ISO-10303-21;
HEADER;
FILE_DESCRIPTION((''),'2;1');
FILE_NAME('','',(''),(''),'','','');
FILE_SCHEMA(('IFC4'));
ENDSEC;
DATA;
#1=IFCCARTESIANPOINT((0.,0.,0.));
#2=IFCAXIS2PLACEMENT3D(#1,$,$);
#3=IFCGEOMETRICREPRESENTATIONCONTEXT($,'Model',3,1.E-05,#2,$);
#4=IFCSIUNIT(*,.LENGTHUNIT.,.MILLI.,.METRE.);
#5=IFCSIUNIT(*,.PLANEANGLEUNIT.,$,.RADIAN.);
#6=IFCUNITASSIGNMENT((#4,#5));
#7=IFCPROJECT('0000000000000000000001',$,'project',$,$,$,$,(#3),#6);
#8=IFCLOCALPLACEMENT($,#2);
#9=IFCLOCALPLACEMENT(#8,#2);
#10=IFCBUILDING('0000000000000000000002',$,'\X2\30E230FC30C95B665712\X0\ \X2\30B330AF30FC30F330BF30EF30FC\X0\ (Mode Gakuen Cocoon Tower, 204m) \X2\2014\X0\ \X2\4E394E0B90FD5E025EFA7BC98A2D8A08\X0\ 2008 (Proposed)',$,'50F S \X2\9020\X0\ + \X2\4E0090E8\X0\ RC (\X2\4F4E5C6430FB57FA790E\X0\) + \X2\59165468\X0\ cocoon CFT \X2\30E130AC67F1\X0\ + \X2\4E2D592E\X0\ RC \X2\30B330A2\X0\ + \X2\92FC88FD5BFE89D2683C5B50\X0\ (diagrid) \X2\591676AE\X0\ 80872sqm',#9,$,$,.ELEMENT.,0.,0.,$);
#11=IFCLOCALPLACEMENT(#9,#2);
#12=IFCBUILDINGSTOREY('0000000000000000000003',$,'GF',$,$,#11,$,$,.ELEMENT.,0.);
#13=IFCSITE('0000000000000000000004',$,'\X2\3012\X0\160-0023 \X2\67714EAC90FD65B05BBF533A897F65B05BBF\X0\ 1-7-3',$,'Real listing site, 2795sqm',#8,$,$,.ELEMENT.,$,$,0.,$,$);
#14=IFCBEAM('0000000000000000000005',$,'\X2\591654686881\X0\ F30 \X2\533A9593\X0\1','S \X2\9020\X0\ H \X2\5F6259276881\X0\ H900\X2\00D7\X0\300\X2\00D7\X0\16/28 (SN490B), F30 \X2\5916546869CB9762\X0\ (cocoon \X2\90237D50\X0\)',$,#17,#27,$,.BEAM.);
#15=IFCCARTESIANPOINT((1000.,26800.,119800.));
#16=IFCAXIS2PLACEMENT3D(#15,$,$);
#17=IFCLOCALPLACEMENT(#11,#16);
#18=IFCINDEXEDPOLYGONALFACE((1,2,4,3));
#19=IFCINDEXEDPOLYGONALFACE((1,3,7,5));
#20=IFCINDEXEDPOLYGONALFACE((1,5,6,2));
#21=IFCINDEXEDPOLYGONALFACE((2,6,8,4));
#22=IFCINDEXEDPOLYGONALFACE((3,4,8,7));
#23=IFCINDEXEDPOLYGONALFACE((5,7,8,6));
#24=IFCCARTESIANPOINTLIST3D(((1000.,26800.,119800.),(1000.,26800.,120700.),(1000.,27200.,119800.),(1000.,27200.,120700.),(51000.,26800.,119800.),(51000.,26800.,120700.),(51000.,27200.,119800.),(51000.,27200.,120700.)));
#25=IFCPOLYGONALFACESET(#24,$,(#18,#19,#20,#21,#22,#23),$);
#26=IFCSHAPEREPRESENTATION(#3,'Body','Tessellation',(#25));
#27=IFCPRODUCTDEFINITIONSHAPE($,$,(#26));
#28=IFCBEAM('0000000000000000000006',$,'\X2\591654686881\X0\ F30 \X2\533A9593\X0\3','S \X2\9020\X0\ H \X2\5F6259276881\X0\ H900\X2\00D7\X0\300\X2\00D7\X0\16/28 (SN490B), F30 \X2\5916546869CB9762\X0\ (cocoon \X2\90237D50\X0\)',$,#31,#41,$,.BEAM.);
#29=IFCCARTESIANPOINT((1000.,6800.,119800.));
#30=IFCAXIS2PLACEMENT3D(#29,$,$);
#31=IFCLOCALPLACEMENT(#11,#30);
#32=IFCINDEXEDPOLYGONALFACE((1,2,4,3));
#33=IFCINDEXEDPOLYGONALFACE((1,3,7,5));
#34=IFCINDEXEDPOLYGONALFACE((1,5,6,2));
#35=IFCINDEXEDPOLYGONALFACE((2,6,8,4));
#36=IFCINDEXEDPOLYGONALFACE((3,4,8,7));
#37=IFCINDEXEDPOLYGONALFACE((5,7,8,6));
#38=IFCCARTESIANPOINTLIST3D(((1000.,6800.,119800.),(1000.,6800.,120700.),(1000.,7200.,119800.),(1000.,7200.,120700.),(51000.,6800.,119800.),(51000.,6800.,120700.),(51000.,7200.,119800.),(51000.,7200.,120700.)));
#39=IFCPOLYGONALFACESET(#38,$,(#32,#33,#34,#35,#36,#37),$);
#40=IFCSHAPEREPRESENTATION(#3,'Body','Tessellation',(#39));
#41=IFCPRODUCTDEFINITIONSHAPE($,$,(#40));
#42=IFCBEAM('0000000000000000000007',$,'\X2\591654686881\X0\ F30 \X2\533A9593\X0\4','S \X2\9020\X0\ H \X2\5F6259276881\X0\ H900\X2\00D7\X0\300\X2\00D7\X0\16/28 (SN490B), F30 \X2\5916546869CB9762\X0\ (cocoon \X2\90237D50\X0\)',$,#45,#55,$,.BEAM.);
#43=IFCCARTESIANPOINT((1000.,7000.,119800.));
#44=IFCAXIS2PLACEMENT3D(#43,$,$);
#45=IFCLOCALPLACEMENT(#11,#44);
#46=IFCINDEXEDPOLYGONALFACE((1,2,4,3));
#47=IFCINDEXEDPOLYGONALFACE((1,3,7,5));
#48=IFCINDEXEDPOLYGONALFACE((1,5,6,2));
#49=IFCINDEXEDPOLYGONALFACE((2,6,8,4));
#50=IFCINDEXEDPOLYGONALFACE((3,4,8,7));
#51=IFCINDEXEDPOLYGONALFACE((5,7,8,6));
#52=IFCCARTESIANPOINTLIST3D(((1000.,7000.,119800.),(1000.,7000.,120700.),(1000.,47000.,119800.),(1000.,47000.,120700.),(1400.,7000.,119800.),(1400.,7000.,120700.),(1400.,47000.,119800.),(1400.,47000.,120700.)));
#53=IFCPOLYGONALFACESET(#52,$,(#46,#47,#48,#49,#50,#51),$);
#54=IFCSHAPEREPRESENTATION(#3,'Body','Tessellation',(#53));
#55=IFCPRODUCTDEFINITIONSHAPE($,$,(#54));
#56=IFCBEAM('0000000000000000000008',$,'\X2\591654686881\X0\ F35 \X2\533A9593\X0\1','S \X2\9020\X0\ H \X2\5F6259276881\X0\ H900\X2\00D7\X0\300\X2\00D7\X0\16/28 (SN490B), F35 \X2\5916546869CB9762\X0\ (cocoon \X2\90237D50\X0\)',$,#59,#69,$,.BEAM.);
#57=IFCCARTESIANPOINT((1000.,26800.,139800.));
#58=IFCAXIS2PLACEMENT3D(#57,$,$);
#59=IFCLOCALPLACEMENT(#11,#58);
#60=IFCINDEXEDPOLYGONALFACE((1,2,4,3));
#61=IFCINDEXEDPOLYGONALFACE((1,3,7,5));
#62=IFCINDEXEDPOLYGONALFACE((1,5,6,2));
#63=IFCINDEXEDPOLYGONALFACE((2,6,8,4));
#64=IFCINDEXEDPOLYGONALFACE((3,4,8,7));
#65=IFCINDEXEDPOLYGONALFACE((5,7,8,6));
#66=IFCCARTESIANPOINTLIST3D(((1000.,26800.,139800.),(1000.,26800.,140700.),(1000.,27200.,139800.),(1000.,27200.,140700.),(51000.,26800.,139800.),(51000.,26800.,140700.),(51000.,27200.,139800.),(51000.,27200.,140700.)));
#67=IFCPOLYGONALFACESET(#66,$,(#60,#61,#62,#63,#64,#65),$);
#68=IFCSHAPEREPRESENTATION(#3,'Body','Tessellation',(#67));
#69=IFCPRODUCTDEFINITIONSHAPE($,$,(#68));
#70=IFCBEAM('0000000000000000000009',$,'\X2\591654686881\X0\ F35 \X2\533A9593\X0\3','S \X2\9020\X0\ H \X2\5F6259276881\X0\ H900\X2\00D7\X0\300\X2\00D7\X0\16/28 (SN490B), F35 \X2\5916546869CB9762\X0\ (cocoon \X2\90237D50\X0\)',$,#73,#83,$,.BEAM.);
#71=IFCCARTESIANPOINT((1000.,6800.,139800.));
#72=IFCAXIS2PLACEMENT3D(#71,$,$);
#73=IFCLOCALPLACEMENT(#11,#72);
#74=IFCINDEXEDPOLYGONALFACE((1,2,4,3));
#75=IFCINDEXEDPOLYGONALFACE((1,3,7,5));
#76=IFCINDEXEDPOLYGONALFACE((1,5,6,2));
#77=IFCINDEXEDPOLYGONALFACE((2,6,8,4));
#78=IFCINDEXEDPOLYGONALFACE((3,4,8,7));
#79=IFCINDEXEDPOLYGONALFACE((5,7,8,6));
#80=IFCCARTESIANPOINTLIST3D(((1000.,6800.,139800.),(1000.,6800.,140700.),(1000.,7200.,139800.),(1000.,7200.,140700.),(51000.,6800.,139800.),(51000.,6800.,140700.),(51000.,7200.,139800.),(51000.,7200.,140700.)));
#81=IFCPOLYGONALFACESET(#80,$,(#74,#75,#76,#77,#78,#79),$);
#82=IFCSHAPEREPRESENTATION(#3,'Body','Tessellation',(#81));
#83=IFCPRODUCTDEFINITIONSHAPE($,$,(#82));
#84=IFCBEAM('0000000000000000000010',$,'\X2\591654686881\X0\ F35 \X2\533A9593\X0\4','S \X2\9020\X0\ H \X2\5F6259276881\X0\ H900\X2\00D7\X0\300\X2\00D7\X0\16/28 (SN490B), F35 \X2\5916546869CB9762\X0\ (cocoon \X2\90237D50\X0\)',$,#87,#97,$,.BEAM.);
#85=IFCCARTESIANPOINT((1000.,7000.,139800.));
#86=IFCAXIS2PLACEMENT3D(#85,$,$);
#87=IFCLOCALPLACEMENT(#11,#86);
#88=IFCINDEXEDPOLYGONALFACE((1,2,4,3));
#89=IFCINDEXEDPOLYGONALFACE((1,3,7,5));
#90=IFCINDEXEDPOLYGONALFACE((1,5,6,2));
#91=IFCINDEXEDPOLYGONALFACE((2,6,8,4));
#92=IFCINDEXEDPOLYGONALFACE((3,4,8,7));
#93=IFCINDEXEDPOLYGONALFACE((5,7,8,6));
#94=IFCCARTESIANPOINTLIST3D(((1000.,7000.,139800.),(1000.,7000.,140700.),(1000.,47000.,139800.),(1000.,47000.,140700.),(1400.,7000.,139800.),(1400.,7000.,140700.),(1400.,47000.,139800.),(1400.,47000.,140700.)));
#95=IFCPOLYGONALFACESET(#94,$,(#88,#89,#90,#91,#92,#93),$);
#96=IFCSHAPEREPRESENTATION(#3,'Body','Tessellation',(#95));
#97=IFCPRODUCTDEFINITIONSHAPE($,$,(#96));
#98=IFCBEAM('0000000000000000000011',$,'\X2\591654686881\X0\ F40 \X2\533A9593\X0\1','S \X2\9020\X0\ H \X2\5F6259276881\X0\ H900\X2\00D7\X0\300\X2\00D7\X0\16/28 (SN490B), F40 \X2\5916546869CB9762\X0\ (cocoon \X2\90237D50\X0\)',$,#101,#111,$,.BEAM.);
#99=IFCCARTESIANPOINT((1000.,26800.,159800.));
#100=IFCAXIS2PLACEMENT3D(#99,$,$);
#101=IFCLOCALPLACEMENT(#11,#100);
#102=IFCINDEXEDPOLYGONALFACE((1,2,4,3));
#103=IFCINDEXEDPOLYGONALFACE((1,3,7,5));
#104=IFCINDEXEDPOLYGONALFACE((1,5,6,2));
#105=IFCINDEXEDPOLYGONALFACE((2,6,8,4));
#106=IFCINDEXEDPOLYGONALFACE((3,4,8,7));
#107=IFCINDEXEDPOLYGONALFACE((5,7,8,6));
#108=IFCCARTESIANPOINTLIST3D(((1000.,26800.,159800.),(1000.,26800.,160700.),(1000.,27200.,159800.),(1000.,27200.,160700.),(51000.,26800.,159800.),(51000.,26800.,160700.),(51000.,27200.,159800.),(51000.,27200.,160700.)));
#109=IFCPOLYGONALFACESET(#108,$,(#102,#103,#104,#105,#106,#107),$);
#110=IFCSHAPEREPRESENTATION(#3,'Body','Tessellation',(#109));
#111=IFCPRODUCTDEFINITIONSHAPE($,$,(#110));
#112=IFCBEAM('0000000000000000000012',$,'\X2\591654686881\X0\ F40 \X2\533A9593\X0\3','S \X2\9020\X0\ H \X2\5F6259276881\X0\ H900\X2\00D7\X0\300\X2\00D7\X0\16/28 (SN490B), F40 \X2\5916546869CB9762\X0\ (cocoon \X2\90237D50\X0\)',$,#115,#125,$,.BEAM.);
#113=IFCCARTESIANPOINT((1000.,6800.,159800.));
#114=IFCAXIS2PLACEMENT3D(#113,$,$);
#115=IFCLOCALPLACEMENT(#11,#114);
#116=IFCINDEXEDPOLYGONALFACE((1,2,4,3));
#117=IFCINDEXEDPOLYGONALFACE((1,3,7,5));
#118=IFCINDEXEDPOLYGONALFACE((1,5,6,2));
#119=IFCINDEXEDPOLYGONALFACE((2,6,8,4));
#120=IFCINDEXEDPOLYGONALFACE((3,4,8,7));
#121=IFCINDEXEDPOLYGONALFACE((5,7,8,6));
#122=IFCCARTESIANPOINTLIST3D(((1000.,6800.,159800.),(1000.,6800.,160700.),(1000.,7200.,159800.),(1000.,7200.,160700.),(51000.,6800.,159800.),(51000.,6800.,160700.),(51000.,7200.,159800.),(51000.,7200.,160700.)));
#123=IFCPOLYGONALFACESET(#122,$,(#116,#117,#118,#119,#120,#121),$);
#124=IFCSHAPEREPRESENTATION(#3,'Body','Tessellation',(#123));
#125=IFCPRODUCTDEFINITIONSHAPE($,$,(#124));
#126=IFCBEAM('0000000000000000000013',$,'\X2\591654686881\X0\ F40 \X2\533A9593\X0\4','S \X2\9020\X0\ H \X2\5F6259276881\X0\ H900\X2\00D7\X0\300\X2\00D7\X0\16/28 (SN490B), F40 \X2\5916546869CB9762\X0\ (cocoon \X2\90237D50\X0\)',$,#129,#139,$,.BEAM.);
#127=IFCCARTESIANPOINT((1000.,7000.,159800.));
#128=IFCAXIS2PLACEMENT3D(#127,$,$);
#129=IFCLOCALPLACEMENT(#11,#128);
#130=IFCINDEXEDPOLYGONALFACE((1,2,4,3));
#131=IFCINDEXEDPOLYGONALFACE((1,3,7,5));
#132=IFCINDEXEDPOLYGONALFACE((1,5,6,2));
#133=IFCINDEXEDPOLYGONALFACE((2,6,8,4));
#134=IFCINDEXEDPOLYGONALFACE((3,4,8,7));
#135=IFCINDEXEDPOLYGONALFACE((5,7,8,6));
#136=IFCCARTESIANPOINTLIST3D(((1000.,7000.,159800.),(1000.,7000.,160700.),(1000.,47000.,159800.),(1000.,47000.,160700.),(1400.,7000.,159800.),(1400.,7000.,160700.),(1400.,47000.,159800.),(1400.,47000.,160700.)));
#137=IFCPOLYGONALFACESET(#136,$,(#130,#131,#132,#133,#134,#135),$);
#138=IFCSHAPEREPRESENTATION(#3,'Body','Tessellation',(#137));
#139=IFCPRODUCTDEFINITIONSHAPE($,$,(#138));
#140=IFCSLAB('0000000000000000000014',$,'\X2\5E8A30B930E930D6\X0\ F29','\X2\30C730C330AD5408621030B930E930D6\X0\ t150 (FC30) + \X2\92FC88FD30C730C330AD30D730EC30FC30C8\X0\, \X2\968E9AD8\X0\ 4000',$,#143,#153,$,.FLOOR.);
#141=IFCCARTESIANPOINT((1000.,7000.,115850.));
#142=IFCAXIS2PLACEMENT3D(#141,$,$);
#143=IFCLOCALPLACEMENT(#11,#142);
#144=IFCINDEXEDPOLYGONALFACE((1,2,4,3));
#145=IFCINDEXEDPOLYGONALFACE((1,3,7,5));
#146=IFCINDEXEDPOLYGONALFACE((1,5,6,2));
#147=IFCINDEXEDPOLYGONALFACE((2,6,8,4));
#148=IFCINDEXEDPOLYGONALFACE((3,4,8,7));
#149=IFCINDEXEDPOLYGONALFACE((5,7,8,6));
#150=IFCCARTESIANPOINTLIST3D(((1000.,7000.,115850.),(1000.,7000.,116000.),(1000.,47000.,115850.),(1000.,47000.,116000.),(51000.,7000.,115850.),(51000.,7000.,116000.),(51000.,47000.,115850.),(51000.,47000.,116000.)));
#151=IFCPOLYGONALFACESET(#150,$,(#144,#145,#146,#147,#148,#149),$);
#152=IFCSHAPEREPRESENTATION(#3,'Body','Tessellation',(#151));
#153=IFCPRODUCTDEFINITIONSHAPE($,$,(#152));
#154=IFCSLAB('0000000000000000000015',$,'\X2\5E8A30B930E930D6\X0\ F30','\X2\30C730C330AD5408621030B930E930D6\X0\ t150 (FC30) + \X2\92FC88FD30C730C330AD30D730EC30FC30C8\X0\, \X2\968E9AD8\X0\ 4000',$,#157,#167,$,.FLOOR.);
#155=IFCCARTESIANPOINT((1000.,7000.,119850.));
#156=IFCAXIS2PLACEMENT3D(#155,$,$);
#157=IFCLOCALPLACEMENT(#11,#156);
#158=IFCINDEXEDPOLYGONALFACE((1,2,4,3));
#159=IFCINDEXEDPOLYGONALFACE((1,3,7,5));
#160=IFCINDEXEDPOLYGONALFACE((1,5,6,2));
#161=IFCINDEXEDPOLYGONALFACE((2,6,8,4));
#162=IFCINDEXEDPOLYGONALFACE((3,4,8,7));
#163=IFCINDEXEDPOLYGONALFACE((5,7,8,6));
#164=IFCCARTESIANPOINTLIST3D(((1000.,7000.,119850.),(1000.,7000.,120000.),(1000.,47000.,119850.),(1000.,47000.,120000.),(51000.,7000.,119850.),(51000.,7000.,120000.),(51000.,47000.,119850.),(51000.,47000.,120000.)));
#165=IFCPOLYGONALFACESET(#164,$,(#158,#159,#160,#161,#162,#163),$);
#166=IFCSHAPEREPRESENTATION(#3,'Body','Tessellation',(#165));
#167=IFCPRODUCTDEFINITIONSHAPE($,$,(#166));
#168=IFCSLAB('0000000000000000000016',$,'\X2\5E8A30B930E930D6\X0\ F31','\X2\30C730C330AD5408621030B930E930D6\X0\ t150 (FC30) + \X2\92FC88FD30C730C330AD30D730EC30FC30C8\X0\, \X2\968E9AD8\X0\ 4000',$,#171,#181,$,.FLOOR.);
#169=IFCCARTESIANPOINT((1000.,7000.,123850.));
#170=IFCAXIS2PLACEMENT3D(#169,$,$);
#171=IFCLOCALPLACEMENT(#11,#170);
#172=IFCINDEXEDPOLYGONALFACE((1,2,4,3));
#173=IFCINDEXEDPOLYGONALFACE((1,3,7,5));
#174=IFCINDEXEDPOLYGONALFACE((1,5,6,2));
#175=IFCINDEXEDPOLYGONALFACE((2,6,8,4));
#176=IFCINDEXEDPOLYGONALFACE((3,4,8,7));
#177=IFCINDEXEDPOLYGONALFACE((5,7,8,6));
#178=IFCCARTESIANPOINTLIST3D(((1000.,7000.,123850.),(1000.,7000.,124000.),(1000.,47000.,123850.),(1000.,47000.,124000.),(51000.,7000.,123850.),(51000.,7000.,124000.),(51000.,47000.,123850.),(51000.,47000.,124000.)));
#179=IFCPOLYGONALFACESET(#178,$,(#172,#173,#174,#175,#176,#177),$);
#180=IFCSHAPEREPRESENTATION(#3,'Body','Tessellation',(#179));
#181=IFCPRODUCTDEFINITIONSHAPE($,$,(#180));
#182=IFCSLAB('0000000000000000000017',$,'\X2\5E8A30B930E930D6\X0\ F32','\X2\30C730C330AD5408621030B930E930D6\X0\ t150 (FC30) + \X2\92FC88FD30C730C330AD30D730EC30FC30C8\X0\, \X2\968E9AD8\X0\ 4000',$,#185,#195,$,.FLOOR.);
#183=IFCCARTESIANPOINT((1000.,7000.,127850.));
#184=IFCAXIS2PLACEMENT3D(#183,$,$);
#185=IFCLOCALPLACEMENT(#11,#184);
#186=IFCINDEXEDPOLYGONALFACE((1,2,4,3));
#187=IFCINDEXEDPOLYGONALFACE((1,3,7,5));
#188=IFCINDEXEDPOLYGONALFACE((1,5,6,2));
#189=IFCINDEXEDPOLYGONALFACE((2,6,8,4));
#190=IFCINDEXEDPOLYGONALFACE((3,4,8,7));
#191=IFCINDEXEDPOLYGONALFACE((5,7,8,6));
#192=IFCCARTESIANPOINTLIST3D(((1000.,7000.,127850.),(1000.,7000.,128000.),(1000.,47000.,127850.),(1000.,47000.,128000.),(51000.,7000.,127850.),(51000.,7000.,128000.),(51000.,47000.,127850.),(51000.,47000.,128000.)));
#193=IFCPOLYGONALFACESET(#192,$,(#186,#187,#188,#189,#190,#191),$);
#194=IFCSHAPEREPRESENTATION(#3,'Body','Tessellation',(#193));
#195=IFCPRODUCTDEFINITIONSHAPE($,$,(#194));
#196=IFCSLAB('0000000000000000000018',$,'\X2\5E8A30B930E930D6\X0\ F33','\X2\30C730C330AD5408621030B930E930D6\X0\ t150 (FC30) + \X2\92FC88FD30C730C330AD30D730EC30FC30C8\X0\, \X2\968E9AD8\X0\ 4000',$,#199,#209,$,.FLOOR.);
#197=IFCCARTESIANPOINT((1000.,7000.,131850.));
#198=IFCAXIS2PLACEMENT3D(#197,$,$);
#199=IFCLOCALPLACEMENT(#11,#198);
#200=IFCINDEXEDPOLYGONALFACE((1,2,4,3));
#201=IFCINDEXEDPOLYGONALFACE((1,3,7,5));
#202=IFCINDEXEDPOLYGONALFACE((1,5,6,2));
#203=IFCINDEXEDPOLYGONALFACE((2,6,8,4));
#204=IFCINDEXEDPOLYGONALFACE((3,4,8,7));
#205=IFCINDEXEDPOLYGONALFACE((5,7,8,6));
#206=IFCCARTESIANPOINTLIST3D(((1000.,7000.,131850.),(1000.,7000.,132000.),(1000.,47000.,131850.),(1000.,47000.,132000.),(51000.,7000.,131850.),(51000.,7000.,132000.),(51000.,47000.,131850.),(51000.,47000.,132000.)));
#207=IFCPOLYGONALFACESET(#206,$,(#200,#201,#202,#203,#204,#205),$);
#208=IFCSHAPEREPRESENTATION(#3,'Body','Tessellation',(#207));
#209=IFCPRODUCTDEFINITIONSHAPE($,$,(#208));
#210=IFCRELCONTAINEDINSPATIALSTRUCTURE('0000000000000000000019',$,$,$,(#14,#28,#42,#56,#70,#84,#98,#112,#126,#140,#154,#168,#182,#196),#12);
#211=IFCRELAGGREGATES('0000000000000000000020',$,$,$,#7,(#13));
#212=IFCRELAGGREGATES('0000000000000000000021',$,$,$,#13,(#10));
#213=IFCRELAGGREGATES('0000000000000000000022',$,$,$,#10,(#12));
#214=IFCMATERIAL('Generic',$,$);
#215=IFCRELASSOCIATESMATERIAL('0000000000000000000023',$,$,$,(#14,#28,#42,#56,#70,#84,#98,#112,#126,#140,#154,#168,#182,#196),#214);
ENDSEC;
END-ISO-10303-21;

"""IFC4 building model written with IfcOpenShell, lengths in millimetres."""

from ifc_helpers import new_model, si_unit, frame, frame_2d, origin, place, context, project, spatial, rectangle, extrude, material, element, save


model = new_model("IFC4")

# Units and contexts
model_context = context("Model", 3, precision=1e-05, world=origin())
ifc_project = project(units=[si_unit("LENGTHUNIT", "METRE", prefix="MILLI"), si_unit("PLANEANGLEUNIT", "RADIAN")], contexts=[model_context])

# Site, building, storey
site_placement = place(None, origin())
site = spatial("IfcSite", under=ifc_project, at=site_placement, Name="〒160-0023 東京都新宿区西新宿 1-7-3", ObjectType="Real listing site, 2795sqm", CompositionType="ELEMENT", RefElevation=0.0)
building_placement = place(site_placement, origin())
building = spatial("IfcBuilding", under=site, at=building_placement, Name="モード学園 コクーンタワー (Mode Gakuen Cocoon Tower, 204m) — 丹下都市建築設計 2008 (Proposed)", ObjectType="50F S 造 + 一部 RC (低層・基礎) + 外周 cocoon CFT メガ柱 + 中央 RC コア + 鋼製対角格子 (diagrid) 外皮 80872sqm", CompositionType="ELEMENT", ElevationOfRefHeight=0.0, ElevationOfTerrain=0.0)
storey_placement = place(building_placement, origin())
storey = spatial("IfcBuildingStorey", under=building, at=storey_placement, Name="GF", CompositionType="ELEMENT", Elevation=0.0)

# Beams
ifc_material_1 = material(Name="Generic")
beam_1_placement = place(storey_placement, frame((1000.0, 26800.0, 119800.0)))
element("IfcBeam", 1, at=beam_1_placement, inside=storey, material=ifc_material_1, Name="外周梁 F30 区間1", Description="S 造 H 形大梁 H900×300×16/28 (SN490B), F30 外周構面 (cocoon 連結)", PredefinedType="BEAM", context=model_context, shape_type="SweptSolid", body=[
    extrude(rectangle(XDim=50000.0, YDim=400.0, at=frame_2d((25000.0, 200.0))), frame((1000.0, 26800.0, 119800.0)), (0.0, 0.0, 1.0), 900.0),
])
beam_2_placement = place(storey_placement, frame((1000.0, 6800.0, 119800.0)))
element("IfcBeam", 2, at=beam_2_placement, inside=storey, material=ifc_material_1, Name="外周梁 F30 区間3", Description="S 造 H 形大梁 H900×300×16/28 (SN490B), F30 外周構面 (cocoon 連結)", PredefinedType="BEAM", context=model_context, shape_type="SweptSolid", body=[
    extrude(rectangle(XDim=50000.0, YDim=400.0, at=frame_2d((25000.0, 200.0))), frame((1000.0, 6800.0, 119800.0)), (0.0, 0.0, 1.0), 900.0),
])
beam_3_placement = place(storey_placement, frame((1000.0, 7000.0, 119800.0)))
element("IfcBeam", 3, at=beam_3_placement, inside=storey, material=ifc_material_1, Name="外周梁 F30 区間4", Description="S 造 H 形大梁 H900×300×16/28 (SN490B), F30 外周構面 (cocoon 連結)", PredefinedType="BEAM", context=model_context, shape_type="SweptSolid", body=[
    extrude(rectangle(XDim=400.0, YDim=40000.0, at=frame_2d((200.0, 20000.0))), frame((1000.0, 7000.0, 119800.0)), (0.0, 0.0, 1.0), 900.0),
])
beam_4_placement = place(storey_placement, frame((1000.0, 26800.0, 139800.0)))
element("IfcBeam", 4, at=beam_4_placement, inside=storey, material=ifc_material_1, Name="外周梁 F35 区間1", Description="S 造 H 形大梁 H900×300×16/28 (SN490B), F35 外周構面 (cocoon 連結)", PredefinedType="BEAM", context=model_context, shape_type="SweptSolid", body=[
    extrude(rectangle(XDim=50000.0, YDim=400.0, at=frame_2d((25000.0, 200.0))), frame((1000.0, 26800.0, 139800.0)), (0.0, 0.0, 1.0), 900.0),
])
beam_5_placement = place(storey_placement, frame((1000.0, 6800.0, 139800.0)))
element("IfcBeam", 5, at=beam_5_placement, inside=storey, material=ifc_material_1, Name="外周梁 F35 区間3", Description="S 造 H 形大梁 H900×300×16/28 (SN490B), F35 外周構面 (cocoon 連結)", PredefinedType="BEAM", context=model_context, shape_type="SweptSolid", body=[
    extrude(rectangle(XDim=50000.0, YDim=400.0, at=frame_2d((25000.0, 200.0))), frame((1000.0, 6800.0, 139800.0)), (0.0, 0.0, 1.0), 900.0),
])
beam_6_placement = place(storey_placement, frame((1000.0, 7000.0, 139800.0)))
element("IfcBeam", 6, at=beam_6_placement, inside=storey, material=ifc_material_1, Name="外周梁 F35 区間4", Description="S 造 H 形大梁 H900×300×16/28 (SN490B), F35 外周構面 (cocoon 連結)", PredefinedType="BEAM", context=model_context, shape_type="SweptSolid", body=[
    extrude(rectangle(XDim=400.0, YDim=40000.0, at=frame_2d((200.0, 20000.0))), frame((1000.0, 7000.0, 139800.0)), (0.0, 0.0, 1.0), 900.0),
])
beam_7_placement = place(storey_placement, frame((1000.0, 26800.0, 159800.0)))
element("IfcBeam", 7, at=beam_7_placement, inside=storey, material=ifc_material_1, Name="外周梁 F40 区間1", Description="S 造 H 形大梁 H900×300×16/28 (SN490B), F40 外周構面 (cocoon 連結)", PredefinedType="BEAM", context=model_context, shape_type="SweptSolid", body=[
    extrude(rectangle(XDim=50000.0, YDim=400.0, at=frame_2d((25000.0, 200.0))), frame((1000.0, 26800.0, 159800.0)), (0.0, 0.0, 1.0), 900.0),
])
beam_8_placement = place(storey_placement, frame((1000.0, 6800.0, 159800.0)))
element("IfcBeam", 8, at=beam_8_placement, inside=storey, material=ifc_material_1, Name="外周梁 F40 区間3", Description="S 造 H 形大梁 H900×300×16/28 (SN490B), F40 外周構面 (cocoon 連結)", PredefinedType="BEAM", context=model_context, shape_type="SweptSolid", body=[
    extrude(rectangle(XDim=50000.0, YDim=400.0, at=frame_2d((25000.0, 200.0))), frame((1000.0, 6800.0, 159800.0)), (0.0, 0.0, 1.0), 900.0),
])
beam_9_placement = place(storey_placement, frame((1000.0, 7000.0, 159800.0)))
element("IfcBeam", 9, at=beam_9_placement, inside=storey, material=ifc_material_1, Name="外周梁 F40 区間4", Description="S 造 H 形大梁 H900×300×16/28 (SN490B), F40 外周構面 (cocoon 連結)", PredefinedType="BEAM", context=model_context, shape_type="SweptSolid", body=[
    extrude(rectangle(XDim=400.0, YDim=40000.0, at=frame_2d((200.0, 20000.0))), frame((1000.0, 7000.0, 159800.0)), (0.0, 0.0, 1.0), 900.0),
])

# Slabs
slab_1_placement = place(storey_placement, frame((1000.0, 7000.0, 115850.0)))
element("IfcSlab", 10, at=slab_1_placement, inside=storey, material=ifc_material_1, Name="床スラブ F29", Description="デッキ合成スラブ t150 (FC30) + 鋼製デッキプレート, 階高 4000", PredefinedType="FLOOR", context=model_context, shape_type="SweptSolid", body=[
    extrude(rectangle(XDim=50000.0, YDim=40000.0, at=frame_2d((25000.0, 20000.0))), frame((1000.0, 7000.0, 115850.0)), (0.0, 0.0, 1.0), 150.0),
])
slab_2_placement = place(storey_placement, frame((1000.0, 7000.0, 119850.0)))
element("IfcSlab", 11, at=slab_2_placement, inside=storey, material=ifc_material_1, Name="床スラブ F30", Description="デッキ合成スラブ t150 (FC30) + 鋼製デッキプレート, 階高 4000", PredefinedType="FLOOR", context=model_context, shape_type="SweptSolid", body=[
    extrude(rectangle(XDim=50000.0, YDim=40000.0, at=frame_2d((25000.0, 20000.0))), frame((1000.0, 7000.0, 119850.0)), (0.0, 0.0, 1.0), 150.0),
])
slab_3_placement = place(storey_placement, frame((1000.0, 7000.0, 123850.0)))
element("IfcSlab", 12, at=slab_3_placement, inside=storey, material=ifc_material_1, Name="床スラブ F31", Description="デッキ合成スラブ t150 (FC30) + 鋼製デッキプレート, 階高 4000", PredefinedType="FLOOR", context=model_context, shape_type="SweptSolid", body=[
    extrude(rectangle(XDim=50000.0, YDim=40000.0, at=frame_2d((25000.0, 20000.0))), frame((1000.0, 7000.0, 123850.0)), (0.0, 0.0, 1.0), 150.0),
])
slab_4_placement = place(storey_placement, frame((1000.0, 7000.0, 127850.0)))
element("IfcSlab", 13, at=slab_4_placement, inside=storey, material=ifc_material_1, Name="床スラブ F32", Description="デッキ合成スラブ t150 (FC30) + 鋼製デッキプレート, 階高 4000", PredefinedType="FLOOR", context=model_context, shape_type="SweptSolid", body=[
    extrude(rectangle(XDim=50000.0, YDim=40000.0, at=frame_2d((25000.0, 20000.0))), frame((1000.0, 7000.0, 127850.0)), (0.0, 0.0, 1.0), 150.0),
])
slab_5_placement = place(storey_placement, frame((1000.0, 7000.0, 131850.0)))
element("IfcSlab", 14, at=slab_5_placement, inside=storey, material=ifc_material_1, Name="床スラブ F33", Description="デッキ合成スラブ t150 (FC30) + 鋼製デッキプレート, 階高 4000", PredefinedType="FLOOR", context=model_context, shape_type="SweptSolid", body=[
    extrude(rectangle(XDim=50000.0, YDim=40000.0, at=frame_2d((25000.0, 20000.0))), frame((1000.0, 7000.0, 131850.0)), (0.0, 0.0, 1.0), 150.0),
])

save(model, "model.ifc")
